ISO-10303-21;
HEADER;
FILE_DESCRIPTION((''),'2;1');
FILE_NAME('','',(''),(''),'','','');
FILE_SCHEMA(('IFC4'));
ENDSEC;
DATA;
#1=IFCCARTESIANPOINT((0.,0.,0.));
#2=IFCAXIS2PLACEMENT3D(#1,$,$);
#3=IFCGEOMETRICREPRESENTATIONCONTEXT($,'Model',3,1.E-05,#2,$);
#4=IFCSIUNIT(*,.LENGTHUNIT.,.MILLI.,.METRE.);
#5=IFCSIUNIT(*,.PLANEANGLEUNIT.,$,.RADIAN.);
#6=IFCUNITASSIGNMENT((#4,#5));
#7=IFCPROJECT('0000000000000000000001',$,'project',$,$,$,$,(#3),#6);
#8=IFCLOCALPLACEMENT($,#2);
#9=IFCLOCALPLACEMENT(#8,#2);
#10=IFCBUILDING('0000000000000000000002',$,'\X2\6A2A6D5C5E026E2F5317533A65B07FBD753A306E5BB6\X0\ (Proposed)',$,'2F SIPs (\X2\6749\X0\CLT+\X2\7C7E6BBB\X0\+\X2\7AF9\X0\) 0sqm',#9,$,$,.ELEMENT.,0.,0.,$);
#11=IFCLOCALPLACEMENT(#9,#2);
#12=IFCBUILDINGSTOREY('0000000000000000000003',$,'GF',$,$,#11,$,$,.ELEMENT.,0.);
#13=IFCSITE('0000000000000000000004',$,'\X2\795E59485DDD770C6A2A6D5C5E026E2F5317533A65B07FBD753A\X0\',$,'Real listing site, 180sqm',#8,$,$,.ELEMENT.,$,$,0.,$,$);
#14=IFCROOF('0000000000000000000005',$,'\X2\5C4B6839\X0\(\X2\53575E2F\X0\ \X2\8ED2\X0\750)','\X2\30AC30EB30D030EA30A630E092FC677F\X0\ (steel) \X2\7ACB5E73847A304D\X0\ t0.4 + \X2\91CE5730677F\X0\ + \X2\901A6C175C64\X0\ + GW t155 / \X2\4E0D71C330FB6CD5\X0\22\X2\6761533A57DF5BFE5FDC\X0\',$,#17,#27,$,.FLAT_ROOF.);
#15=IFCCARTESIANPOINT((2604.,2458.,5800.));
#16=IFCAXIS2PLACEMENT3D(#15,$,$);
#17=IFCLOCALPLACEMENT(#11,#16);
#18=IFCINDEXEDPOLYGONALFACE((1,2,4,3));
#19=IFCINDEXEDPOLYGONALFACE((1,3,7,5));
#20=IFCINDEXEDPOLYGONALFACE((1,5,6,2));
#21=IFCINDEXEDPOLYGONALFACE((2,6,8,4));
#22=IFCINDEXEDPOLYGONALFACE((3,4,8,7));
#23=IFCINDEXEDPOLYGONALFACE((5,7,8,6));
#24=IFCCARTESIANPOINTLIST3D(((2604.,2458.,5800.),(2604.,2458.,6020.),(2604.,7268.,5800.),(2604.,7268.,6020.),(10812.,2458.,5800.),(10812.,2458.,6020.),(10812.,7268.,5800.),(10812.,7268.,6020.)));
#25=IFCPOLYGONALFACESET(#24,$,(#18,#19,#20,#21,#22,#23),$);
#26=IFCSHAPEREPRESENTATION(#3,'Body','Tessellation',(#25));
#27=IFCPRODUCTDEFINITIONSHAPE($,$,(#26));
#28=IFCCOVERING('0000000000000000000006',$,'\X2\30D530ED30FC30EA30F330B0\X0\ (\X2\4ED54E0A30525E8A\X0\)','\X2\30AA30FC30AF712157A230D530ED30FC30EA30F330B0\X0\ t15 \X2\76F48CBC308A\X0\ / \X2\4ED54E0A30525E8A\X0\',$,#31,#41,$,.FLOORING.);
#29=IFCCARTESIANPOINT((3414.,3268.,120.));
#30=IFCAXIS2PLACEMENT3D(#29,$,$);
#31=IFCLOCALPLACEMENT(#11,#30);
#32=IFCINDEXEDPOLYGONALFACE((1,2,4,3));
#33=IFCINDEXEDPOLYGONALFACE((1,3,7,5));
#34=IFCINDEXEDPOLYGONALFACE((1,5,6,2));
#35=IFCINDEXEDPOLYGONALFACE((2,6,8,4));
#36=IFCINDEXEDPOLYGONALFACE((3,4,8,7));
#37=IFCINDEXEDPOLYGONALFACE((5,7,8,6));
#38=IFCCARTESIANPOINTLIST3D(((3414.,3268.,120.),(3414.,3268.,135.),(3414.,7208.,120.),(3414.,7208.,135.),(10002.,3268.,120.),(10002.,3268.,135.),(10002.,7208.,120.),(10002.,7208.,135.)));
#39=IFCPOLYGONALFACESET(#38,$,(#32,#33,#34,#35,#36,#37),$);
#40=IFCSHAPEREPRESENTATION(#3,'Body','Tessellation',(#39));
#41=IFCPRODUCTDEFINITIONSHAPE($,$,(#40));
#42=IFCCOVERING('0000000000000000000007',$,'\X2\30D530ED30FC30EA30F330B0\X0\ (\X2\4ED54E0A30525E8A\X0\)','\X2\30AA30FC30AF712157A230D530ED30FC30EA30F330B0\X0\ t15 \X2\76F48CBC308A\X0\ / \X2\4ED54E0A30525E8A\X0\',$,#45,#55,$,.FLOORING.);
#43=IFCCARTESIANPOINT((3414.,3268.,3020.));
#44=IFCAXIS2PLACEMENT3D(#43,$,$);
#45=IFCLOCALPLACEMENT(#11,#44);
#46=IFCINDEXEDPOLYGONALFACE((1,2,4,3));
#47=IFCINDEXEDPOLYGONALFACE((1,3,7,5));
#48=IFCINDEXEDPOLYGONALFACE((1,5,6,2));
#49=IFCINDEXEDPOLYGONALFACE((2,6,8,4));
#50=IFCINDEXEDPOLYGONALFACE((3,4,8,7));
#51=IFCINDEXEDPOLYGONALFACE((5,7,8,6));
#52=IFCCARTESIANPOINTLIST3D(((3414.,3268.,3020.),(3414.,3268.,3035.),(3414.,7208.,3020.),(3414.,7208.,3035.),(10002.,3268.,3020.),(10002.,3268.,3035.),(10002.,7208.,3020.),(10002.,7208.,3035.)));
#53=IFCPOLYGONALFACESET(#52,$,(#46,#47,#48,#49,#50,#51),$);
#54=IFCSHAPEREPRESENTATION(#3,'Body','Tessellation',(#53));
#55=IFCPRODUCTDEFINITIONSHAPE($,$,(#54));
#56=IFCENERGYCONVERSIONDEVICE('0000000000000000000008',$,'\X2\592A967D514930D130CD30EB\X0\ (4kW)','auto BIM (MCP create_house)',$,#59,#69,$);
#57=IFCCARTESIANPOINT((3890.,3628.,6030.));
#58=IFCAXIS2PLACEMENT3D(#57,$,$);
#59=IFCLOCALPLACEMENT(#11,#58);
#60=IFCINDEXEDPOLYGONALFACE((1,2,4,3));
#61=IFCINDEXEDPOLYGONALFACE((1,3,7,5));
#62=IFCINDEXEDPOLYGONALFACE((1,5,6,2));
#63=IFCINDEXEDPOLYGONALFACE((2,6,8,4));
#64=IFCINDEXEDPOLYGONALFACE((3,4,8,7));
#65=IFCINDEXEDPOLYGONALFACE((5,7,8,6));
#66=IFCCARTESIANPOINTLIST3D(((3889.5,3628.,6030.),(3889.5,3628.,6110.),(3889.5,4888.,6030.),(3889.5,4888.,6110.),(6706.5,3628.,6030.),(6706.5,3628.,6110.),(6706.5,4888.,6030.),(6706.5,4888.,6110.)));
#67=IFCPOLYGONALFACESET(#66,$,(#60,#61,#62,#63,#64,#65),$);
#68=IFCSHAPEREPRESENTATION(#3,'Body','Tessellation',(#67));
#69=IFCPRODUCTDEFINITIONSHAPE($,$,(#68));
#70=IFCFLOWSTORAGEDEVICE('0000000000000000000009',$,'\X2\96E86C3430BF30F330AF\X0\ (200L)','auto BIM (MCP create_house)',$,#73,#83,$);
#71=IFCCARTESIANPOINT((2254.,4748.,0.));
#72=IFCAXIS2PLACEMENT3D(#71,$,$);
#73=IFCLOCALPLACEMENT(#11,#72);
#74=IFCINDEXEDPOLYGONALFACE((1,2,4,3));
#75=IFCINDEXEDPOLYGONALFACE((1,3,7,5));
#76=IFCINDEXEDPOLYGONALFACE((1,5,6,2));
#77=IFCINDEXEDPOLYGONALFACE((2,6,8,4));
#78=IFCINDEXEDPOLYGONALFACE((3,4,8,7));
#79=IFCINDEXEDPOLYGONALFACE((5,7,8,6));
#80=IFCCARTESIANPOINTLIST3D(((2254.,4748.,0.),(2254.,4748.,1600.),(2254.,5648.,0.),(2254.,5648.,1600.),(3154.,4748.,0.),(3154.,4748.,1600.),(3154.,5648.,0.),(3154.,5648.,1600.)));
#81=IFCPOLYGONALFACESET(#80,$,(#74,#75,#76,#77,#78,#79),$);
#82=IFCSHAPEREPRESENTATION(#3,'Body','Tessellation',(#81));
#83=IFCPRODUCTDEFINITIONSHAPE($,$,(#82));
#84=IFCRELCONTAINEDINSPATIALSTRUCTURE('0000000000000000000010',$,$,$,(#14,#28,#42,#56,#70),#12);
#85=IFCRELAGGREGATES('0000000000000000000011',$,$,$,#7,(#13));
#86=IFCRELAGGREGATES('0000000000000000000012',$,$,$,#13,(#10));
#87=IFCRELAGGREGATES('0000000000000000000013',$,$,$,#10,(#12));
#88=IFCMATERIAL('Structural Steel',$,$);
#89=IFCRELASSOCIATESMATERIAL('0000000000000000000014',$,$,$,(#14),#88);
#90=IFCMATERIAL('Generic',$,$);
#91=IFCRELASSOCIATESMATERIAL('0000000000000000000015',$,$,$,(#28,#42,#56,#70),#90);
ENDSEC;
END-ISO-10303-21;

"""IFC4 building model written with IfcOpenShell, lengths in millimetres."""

from ifc_helpers import new_model, si_unit, frame, frame_2d, origin, place, context, project, spatial, rectangle, extrude, material, element, save


model = new_model("IFC4")

# Units and contexts
model_context = context("Model", 3, precision=1e-05, world=origin())
ifc_project = project(units=[si_unit("LENGTHUNIT", "METRE", prefix="MILLI"), si_unit("PLANEANGLEUNIT", "RADIAN")], contexts=[model_context])

# Site, building, storey
site_placement = place(None, origin())
site = spatial("IfcSite", under=ifc_project, at=site_placement, Name="神奈川県横浜市港北区新羽町", ObjectType="Real listing site, 180sqm", CompositionType="ELEMENT", RefElevation=0.0)
building_placement = place(site_placement, origin())
building = spatial("IfcBuilding", under=site, at=building_placement, Name="横浜市港北区新羽町の家 (Proposed)", ObjectType="2F SIPs (杉CLT+籾殻+竹) 0sqm", CompositionType="ELEMENT", ElevationOfRefHeight=0.0, ElevationOfTerrain=0.0)
storey_placement = place(building_placement, origin())
storey = spatial("IfcBuildingStorey", under=building, at=storey_placement, Name="GF", CompositionType="ELEMENT", Elevation=0.0)

# Roof
ifc_material_1 = material(Name="Structural Steel")
for number, where, name in (
    (1, (2604.0, 2458.0, 5800.0), "屋根(南帯 軒750)"),
):
    element("IfcRoof", number, at=place(storey_placement, frame(where)), inside=storey, material=ifc_material_1, Name=name, Description="ガルバリウム鋼板 (steel) 立平葺き t0.4 + 野地板 + 通気層 + GW t155 / 不燃・法22条区域対応", PredefinedType="FLAT_ROOF", context=model_context, shape_type="SweptSolid", body=[
        extrude(rectangle(XDim=8208.0, YDim=4810.0, at=frame_2d((4104.0, 2405.0))), frame((2604.0, 2458.0, 5800.0)), (0.0, 0.0, 1.0), 220.0),
    ])

# Coverings
ifc_material_2 = material(Name="Generic")
covering_1_placement = place(storey_placement, frame((3414.0, 3268.0, 120.0)))
element("IfcCovering", 2, at=covering_1_placement, inside=storey, material=ifc_material_2, Name="フローリング (仕上げ床)", Description="オーク無垢フローリング t15 直貼り / 仕上げ床", PredefinedType="FLOORING", context=model_context, shape_type="SweptSolid", body=[
    extrude(rectangle(XDim=6588.0, YDim=3940.0, at=frame_2d((3294.0, 1970.0))), frame((3414.0, 3268.0, 120.0)), (0.0, 0.0, 1.0), 15.0),
])
covering_2_placement = place(storey_placement, frame((3414.0, 3268.0, 3020.0)))
element("IfcCovering", 3, at=covering_2_placement, inside=storey, material=ifc_material_2, Name="フローリング (仕上げ床)", Description="オーク無垢フローリング t15 直貼り / 仕上げ床", PredefinedType="FLOORING", context=model_context, shape_type="SweptSolid", body=[
    extrude(rectangle(XDim=6588.0, YDim=3940.0, at=frame_2d((3294.0, 1970.0))), frame((3414.0, 3268.0, 3020.0)), (0.0, 0.0, 1.0), 15.0),
])

# Energy conversion device
energy_conversion_device_placement = place(storey_placement, frame((3890.0, 3628.0, 6030.0)))
element("IfcEnergyConversionDevice", 4, at=energy_conversion_device_placement, inside=storey, material=ifc_material_2, Name="太陽光パネル (4kW)", Description="auto BIM (MCP create_house)", context=model_context, shape_type="SweptSolid", body=[
    extrude(rectangle(XDim=2817.0, YDim=1260.0, at=frame_2d((1408.0, 630.0))), frame((3890.0, 3628.0, 6030.0)), (0.0, 0.0, 1.0), 80.0),
])

# Flow storage device
flow_storage_device_placement = place(storey_placement, frame((2254.0, 4748.0, 0.0)))
element("IfcFlowStorageDevice", 5, at=flow_storage_device_placement, inside=storey, material=ifc_material_2, Name="雨水タンク (200L)", Description="auto BIM (MCP create_house)", context=model_context, shape_type="SweptSolid", body=[
    extrude(rectangle(XDim=900.0, YDim=900.0, at=frame_2d((450.0, 450.0))), frame((2254.0, 4748.0, 0.0)), (0.0, 0.0, 1.0), 1600.0),
])

save(model, "model.ifc")
